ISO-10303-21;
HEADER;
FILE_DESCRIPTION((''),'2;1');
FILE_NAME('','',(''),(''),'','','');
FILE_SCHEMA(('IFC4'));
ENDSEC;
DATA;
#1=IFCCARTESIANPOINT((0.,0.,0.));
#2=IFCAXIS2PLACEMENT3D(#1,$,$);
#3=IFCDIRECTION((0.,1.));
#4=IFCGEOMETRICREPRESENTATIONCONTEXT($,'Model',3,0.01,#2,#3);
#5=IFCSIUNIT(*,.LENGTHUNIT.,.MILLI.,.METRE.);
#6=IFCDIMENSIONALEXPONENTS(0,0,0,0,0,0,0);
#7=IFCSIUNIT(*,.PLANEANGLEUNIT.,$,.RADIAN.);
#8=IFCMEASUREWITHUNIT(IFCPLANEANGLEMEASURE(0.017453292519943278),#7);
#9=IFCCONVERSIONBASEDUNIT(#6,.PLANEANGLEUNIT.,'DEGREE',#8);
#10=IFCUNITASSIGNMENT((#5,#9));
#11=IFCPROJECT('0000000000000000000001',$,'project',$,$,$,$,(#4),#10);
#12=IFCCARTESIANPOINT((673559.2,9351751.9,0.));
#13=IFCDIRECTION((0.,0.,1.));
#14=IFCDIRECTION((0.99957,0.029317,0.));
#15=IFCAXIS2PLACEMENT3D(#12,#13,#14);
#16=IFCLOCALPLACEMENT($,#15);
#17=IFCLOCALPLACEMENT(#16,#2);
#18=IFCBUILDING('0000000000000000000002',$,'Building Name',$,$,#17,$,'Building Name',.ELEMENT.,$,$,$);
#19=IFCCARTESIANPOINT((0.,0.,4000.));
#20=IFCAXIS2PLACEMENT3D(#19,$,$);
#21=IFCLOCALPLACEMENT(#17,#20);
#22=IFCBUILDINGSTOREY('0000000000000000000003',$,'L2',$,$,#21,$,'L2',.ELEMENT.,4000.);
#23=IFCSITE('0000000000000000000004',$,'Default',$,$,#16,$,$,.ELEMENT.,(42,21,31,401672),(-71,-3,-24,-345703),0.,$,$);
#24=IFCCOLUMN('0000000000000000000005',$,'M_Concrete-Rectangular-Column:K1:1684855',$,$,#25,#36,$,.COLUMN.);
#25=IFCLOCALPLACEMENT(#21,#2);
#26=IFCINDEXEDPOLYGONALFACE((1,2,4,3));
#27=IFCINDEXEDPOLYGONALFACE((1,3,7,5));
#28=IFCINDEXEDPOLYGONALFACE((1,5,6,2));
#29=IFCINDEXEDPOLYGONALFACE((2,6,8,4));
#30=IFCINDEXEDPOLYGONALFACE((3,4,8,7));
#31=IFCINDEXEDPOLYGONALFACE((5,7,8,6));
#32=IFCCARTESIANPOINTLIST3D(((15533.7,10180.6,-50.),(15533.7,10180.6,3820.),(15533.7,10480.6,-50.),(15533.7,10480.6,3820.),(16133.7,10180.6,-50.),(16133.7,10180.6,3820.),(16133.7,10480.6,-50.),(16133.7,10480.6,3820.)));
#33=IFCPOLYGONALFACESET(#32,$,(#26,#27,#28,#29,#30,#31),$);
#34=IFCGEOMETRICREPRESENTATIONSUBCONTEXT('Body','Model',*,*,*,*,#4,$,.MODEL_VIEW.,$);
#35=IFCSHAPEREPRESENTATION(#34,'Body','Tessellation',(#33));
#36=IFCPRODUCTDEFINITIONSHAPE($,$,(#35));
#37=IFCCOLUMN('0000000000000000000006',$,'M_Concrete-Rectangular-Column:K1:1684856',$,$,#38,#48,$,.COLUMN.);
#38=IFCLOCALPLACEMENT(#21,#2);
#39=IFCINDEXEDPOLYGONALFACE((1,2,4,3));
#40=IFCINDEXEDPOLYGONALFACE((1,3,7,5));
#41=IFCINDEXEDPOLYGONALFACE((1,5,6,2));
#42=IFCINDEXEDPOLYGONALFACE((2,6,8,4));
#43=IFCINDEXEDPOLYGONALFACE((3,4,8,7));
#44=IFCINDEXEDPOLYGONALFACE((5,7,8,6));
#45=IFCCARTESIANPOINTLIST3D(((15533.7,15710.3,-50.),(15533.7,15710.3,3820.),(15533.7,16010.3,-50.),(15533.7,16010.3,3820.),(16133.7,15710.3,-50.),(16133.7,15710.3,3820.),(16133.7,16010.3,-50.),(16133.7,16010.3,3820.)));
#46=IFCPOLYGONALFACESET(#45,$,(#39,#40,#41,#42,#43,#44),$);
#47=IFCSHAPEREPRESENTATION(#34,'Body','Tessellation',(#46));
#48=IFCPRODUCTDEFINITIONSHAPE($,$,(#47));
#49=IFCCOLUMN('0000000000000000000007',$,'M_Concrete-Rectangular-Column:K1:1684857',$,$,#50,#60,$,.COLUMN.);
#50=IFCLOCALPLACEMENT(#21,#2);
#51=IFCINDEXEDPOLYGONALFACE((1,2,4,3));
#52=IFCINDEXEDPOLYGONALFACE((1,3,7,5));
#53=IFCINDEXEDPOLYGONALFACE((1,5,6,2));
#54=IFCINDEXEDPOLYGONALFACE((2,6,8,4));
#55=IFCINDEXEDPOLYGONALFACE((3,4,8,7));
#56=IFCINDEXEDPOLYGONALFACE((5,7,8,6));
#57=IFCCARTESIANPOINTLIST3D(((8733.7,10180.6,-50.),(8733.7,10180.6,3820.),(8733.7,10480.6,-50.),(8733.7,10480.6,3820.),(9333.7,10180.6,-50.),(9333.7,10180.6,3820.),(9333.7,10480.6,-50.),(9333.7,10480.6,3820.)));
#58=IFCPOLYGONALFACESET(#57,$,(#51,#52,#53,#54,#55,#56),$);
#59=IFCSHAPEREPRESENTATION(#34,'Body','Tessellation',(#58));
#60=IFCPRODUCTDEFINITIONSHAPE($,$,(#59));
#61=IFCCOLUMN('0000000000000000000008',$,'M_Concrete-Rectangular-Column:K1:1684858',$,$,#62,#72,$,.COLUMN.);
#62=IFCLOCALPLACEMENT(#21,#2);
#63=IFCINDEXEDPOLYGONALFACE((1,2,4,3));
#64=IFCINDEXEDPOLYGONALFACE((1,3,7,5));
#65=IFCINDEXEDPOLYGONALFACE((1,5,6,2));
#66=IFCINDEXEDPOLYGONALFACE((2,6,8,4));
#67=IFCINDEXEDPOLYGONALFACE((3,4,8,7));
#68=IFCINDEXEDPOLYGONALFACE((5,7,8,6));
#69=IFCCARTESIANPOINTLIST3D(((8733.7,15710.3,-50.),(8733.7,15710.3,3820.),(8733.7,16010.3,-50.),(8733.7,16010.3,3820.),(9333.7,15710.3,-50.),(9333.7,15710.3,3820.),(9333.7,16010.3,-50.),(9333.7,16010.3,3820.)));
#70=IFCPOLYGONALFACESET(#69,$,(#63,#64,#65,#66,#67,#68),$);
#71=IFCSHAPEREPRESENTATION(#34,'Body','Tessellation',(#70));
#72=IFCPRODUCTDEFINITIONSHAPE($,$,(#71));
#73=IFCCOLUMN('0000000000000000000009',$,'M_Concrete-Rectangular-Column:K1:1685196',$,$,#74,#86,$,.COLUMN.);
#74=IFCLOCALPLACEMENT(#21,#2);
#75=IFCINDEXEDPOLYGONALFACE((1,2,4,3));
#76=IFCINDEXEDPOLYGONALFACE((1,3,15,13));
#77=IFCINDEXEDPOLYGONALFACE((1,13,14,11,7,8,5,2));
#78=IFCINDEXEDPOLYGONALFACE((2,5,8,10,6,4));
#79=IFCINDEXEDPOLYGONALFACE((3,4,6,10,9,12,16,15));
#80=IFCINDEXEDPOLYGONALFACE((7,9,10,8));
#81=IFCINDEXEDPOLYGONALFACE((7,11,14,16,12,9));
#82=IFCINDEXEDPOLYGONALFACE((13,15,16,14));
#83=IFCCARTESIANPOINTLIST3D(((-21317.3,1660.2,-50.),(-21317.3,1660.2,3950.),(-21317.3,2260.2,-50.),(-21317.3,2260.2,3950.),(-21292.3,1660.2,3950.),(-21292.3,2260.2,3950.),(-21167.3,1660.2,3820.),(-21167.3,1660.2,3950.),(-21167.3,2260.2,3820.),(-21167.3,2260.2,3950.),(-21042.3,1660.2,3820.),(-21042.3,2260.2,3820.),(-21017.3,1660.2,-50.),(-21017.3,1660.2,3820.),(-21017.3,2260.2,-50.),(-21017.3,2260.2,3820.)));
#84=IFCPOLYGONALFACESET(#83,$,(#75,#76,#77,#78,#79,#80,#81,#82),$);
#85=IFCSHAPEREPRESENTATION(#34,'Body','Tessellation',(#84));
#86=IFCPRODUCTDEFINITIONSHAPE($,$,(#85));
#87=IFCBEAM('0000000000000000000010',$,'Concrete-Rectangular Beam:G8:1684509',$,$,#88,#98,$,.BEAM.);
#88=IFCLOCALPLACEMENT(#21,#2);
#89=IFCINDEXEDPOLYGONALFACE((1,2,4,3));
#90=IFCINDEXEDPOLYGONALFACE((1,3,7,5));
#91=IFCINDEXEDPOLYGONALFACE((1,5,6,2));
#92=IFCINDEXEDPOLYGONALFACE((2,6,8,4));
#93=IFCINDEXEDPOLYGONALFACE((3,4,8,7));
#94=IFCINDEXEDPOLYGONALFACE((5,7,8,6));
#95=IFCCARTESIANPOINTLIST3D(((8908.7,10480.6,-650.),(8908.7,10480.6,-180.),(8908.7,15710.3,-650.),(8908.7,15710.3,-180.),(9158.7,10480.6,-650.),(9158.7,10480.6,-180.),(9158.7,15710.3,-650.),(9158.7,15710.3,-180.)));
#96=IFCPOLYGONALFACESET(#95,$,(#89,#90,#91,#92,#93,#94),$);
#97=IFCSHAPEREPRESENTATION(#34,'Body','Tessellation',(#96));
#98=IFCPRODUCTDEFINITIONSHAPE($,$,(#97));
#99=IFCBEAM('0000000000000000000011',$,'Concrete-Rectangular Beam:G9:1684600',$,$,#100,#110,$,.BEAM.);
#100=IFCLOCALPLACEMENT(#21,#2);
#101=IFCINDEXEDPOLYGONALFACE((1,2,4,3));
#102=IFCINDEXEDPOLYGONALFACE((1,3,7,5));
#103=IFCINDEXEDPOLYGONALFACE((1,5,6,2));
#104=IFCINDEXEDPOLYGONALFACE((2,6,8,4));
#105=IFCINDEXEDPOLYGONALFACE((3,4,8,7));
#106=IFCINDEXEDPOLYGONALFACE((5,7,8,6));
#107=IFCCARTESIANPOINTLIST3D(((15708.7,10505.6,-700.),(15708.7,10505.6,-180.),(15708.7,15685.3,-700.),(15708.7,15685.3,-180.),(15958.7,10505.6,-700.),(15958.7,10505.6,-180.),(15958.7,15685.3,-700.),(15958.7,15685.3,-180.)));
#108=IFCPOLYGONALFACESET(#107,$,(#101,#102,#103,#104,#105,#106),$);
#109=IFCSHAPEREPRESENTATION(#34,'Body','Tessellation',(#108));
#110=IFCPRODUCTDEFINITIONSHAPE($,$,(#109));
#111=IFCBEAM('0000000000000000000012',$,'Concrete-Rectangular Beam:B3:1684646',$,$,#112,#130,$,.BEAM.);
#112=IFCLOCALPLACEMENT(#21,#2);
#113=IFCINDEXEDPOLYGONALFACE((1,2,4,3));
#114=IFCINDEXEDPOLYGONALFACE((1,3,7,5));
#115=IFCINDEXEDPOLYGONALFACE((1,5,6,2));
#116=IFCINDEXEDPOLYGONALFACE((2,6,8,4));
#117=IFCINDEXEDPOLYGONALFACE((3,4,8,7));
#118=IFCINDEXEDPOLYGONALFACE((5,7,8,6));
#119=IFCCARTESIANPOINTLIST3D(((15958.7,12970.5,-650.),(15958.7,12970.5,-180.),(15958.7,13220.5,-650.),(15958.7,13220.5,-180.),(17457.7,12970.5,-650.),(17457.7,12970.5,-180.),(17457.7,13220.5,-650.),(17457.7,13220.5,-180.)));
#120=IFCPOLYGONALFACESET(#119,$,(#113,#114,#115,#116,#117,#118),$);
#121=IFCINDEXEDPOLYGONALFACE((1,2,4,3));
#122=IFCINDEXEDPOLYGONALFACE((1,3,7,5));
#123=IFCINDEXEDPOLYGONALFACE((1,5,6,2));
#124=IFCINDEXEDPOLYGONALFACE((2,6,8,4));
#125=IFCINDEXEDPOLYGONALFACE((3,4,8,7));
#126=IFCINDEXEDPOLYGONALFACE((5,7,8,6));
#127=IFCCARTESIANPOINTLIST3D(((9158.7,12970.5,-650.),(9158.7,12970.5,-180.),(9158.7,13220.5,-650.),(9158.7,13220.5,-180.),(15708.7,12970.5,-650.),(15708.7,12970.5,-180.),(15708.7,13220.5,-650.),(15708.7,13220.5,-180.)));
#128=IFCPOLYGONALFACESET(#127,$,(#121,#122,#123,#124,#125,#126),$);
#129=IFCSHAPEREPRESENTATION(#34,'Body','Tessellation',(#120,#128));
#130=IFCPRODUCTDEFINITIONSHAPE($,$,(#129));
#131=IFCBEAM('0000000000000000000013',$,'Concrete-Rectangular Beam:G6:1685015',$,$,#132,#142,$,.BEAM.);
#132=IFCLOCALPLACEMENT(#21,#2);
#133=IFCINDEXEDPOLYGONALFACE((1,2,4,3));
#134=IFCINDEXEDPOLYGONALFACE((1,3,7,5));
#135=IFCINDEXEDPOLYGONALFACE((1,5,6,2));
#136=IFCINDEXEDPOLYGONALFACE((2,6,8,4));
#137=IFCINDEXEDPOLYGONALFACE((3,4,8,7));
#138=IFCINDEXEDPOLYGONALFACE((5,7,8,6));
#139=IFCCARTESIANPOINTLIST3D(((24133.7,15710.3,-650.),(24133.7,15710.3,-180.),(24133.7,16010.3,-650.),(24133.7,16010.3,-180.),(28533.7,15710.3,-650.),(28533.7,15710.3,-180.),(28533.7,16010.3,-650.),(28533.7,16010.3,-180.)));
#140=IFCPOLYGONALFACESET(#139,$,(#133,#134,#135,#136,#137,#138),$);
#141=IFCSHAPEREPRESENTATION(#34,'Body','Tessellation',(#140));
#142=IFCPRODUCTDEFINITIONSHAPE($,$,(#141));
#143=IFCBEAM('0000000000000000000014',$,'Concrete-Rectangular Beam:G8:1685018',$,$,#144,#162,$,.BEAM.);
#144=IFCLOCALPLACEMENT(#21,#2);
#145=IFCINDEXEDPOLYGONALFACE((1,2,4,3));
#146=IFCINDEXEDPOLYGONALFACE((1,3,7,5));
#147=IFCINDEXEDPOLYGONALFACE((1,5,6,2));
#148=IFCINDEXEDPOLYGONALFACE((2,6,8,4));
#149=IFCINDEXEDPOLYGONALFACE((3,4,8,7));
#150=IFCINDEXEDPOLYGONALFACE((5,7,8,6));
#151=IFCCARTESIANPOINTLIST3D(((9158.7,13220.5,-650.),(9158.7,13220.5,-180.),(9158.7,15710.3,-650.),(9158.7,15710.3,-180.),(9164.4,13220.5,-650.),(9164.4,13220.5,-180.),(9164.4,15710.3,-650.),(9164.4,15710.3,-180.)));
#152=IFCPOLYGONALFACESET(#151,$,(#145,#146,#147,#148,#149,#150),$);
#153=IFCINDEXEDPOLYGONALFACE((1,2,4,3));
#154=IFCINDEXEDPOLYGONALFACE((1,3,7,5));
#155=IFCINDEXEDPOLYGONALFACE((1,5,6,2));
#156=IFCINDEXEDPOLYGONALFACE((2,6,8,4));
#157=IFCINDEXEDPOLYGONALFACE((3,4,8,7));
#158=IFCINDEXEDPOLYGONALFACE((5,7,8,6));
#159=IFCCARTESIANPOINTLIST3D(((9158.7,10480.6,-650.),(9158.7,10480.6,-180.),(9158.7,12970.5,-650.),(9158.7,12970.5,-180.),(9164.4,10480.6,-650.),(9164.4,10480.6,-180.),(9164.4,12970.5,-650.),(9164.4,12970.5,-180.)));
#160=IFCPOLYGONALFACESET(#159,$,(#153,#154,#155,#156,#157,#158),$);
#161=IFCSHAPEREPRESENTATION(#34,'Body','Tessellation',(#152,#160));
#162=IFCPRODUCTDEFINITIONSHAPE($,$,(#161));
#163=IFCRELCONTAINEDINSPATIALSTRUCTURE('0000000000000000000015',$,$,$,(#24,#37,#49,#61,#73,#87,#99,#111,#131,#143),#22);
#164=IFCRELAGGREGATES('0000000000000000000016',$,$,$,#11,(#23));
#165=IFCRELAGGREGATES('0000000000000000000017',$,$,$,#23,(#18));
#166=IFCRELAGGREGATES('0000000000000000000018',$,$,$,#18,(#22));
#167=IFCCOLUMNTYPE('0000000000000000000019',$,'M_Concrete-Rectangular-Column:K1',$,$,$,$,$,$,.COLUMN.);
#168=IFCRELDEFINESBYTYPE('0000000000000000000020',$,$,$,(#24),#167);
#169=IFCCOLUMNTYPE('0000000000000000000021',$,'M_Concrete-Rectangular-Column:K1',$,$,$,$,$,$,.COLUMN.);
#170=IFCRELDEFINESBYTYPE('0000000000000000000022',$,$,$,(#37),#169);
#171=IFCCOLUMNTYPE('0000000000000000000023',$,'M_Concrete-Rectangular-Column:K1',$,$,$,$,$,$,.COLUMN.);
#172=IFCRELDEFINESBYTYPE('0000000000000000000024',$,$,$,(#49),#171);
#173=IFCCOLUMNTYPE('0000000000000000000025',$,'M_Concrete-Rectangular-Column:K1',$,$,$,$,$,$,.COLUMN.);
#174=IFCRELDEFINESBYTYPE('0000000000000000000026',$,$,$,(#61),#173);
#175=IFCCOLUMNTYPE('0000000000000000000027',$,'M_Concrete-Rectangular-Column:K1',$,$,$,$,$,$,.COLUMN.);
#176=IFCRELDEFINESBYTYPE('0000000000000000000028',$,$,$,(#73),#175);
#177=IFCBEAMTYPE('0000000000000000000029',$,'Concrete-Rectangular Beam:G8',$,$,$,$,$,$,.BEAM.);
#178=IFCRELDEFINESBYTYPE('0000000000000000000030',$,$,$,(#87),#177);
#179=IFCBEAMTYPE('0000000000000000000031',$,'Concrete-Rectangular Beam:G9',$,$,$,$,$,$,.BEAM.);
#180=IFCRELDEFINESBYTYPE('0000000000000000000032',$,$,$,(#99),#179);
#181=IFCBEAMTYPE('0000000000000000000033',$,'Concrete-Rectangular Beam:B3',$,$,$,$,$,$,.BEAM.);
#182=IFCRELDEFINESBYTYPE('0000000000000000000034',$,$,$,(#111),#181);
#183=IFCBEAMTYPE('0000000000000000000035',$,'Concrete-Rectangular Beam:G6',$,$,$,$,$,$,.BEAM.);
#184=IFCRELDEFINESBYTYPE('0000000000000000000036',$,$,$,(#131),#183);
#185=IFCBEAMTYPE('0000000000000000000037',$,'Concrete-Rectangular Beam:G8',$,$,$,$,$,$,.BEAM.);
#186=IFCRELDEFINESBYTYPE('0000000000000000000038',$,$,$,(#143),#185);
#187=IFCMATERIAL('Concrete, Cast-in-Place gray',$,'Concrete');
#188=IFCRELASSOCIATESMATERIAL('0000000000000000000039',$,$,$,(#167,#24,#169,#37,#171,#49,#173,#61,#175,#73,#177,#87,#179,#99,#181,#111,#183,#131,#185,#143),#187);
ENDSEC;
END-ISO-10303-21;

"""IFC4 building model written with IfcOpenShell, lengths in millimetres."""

from ifc_helpers import new_model, entity, si_unit, converted_unit, direction, frame, origin, place, context, subcontext, project, spatial, indexed_curve, outline, extrude, source, transform, mapped, material, type_object, type_shapes, element, save


model = new_model("IFC4")

# Units and contexts
model_context = context("Model", 3, precision=0.01, world=origin(), true_north=direction((0.0, 1.0)))
body_context = subcontext(model_context, "Body", "Model", "MODEL_VIEW")
ifc_project = project(units=[si_unit("LENGTHUNIT", "METRE", prefix="MILLI"), converted_unit("PLANEANGLEUNIT", "DEGREE", entity("IfcPlaneAngleMeasure", 0.017453292519943278), si_unit("PLANEANGLEUNIT", "RADIAN"), dimensions=[0, 0, 0, 0, 0, 0, 0])], contexts=[model_context])

# Site, building, storey
site_placement = place(None, frame((673559.2, 9351751.9, 0.0), z_axis=(0.0, 0.0, 1.0), x_axis=(0.99957, 0.029317, 0.0)))
site = spatial("IfcSite", under=ifc_project, at=site_placement, Name="Default", CompositionType="ELEMENT", RefLatitude=(42, 21, 31, 401672), RefLongitude=(-71, -3, -24, -345703), RefElevation=0.0)
building_placement = place(site_placement, origin())
building = spatial("IfcBuilding", under=site, at=building_placement, Name="Building Name", LongName="Building Name", CompositionType="ELEMENT")
storey_placement = place(building_placement, frame((0.0, 0.0, 4000.0)))
storey = spatial("IfcBuildingStorey", under=building, at=storey_placement, Name="L2", LongName="L2", CompositionType="ELEMENT", Elevation=4000.0)

# Columns
ifc_material = material(Name="Concrete, Cast-in-Place gray", Category="Concrete")
column_type_1 = type_object("IfcColumnType", Name="M_Concrete-Rectangular-Column:K1", PredefinedType="COLUMN", material=ifc_material)
shared_shape_1 = source(origin(), body_context, "Body", "SweptSolid", [
    extrude(outline(indexed_curve([(-150.0, -300.0), (150.0, -300.0), (150.0, 300.0), (-150.0, 300.0), (-150.0, -300.0)], self_intersect=False)), frame((15833.7, 10330.6, 3950.0), z_axis=(0.0, 0.0, 1.0), x_axis=(0.0, -1.0, 0.0)), (0.0, 0.0, 1.0), 3870.0),
])
type_shapes(column_type_1, [shared_shape_1])
column_1_placement = place(storey_placement, frame((0.0, 0.0, -4000.0)))
element("IfcColumn", 1, at=column_1_placement, inside=storey, type_object=column_type_1, material=ifc_material, Name="M_Concrete-Rectangular-Column:K1:1684855", PredefinedType="COLUMN", context=body_context, shape_type="MappedRepresentation", body=[
    mapped(shared_shape_1, transform((0.0, 0.0, 0.0), scale=1.0)),
])
column_type_2 = type_object("IfcColumnType", Name="M_Concrete-Rectangular-Column:K1", PredefinedType="COLUMN", material=ifc_material)
shared_shape_2 = source(origin(), body_context, "Body", "SweptSolid", [
    extrude(outline(indexed_curve([(-150.0, -300.0), (150.0, -300.0), (150.0, 300.0), (-150.0, 300.0), (-150.0, -300.0)], self_intersect=False)), frame((15833.7, 15860.3, 3950.0), z_axis=(0.0, 0.0, 1.0), x_axis=(0.0, -1.0, 0.0)), (0.0, 0.0, 1.0), 3870.0),
])
type_shapes(column_type_2, [shared_shape_2])
column_2_placement = place(storey_placement, frame((0.0, 0.0, -4000.0)))
element("IfcColumn", 2, at=column_2_placement, inside=storey, type_object=column_type_2, material=ifc_material, Name="M_Concrete-Rectangular-Column:K1:1684856", PredefinedType="COLUMN", context=body_context, shape_type="MappedRepresentation", body=[
    mapped(shared_shape_2, transform((0.0, 0.0, 0.0), scale=1.0)),
])
column_type_3 = type_object("IfcColumnType", Name="M_Concrete-Rectangular-Column:K1", PredefinedType="COLUMN", material=ifc_material)
shared_shape_3 = source(origin(), body_context, "Body", "SweptSolid", [
    extrude(outline(indexed_curve([(-150.0, -300.0), (150.0, -300.0), (150.0, 300.0), (-150.0, 300.0), (-150.0, -300.0)], self_intersect=False)), frame((9033.7, 10330.6, 3950.0), z_axis=(0.0, 0.0, 1.0), x_axis=(0.0, -1.0, 0.0)), (0.0, 0.0, 1.0), 3870.0),
])
type_shapes(column_type_3, [shared_shape_3])
column_3_placement = place(storey_placement, frame((0.0, 0.0, -4000.0)))
element("IfcColumn", 3, at=column_3_placement, inside=storey, type_object=column_type_3, material=ifc_material, Name="M_Concrete-Rectangular-Column:K1:1684857", PredefinedType="COLUMN", context=body_context, shape_type="MappedRepresentation", body=[
    mapped(shared_shape_3, transform((0.0, 0.0, 0.0), scale=1.0)),
])
column_type_4 = type_object("IfcColumnType", Name="M_Concrete-Rectangular-Column:K1", PredefinedType="COLUMN", material=ifc_material)
shared_shape_4 = source(origin(), body_context, "Body", "SweptSolid", [
    extrude(outline(indexed_curve([(-150.0, -300.0), (150.0, -300.0), (150.0, 300.0), (-150.0, 300.0), (-150.0, -300.0)], self_intersect=False)), frame((9033.7, 15860.3, 3950.0), z_axis=(0.0, 0.0, 1.0), x_axis=(0.0, -1.0, 0.0)), (0.0, 0.0, 1.0), 3870.0),
])
type_shapes(column_type_4, [shared_shape_4])
column_4_placement = place(storey_placement, frame((0.0, 0.0, -4000.0)))
element("IfcColumn", 4, at=column_4_placement, inside=storey, type_object=column_type_4, material=ifc_material, Name="M_Concrete-Rectangular-Column:K1:1684858", PredefinedType="COLUMN", context=body_context, shape_type="MappedRepresentation", body=[
    mapped(shared_shape_4, transform((0.0, 0.0, 0.0), scale=1.0)),
])
column_type_5 = type_object("IfcColumnType", Name="M_Concrete-Rectangular-Column:K1", PredefinedType="COLUMN", material=ifc_material)
shared_shape_5 = source(origin(), body_context, "Body", "SweptSolid", [
    extrude(outline(indexed_curve([(-2951.3, -150.0), (1048.7, -150.0), (1048.7, -125.0), (1048.7, 0.0), (918.8, 0.0), (918.8, 125.0), (918.8, 150.0), (-2951.3, 150.0), (-2951.3, -150.0)], self_intersect=False)), frame((-21167.3, 1660.2, 6901.3), z_axis=(0.0, 1.0, 0.0), x_axis=(0.0, 0.0, 1.0)), (0.0, 0.0, 1.0), 600.0),
])
type_shapes(column_type_5, [shared_shape_5])
column_5_placement = place(storey_placement, frame((0.0, 0.0, -4000.0)))
element("IfcColumn", 5, at=column_5_placement, inside=storey, type_object=column_type_5, material=ifc_material, Name="M_Concrete-Rectangular-Column:K1:1685196", PredefinedType="COLUMN", context=body_context, shape_type="MappedRepresentation", body=[
    mapped(shared_shape_5, transform((0.0, 0.0, 0.0), scale=1.0)),
])

# Beams
beam_type_1 = type_object("IfcBeamType", Name="Concrete-Rectangular Beam:G8", PredefinedType="BEAM", material=ifc_material)
shared_shape_6 = source(origin(), body_context, "Body", "SweptSolid", [
    extrude(outline(indexed_curve([(-125.0, -235.0), (125.0, -235.0), (125.0, 235.0), (-125.0, 235.0), (-125.0, -235.0)], self_intersect=False)), frame((9033.7, 15710.3, 3585.0), z_axis=(0.0, -1.0, 0.0), x_axis=(-1.0, 0.0, 0.0)), (0.0, 0.0, 1.0), 5229.7),
])
type_shapes(beam_type_1, [shared_shape_6])
beam_1_placement = place(storey_placement, frame((0.0, 0.0, -4000.0)))
element("IfcBeam", 6, at=beam_1_placement, inside=storey, type_object=beam_type_1, material=ifc_material, Name="Concrete-Rectangular Beam:G8:1684509", PredefinedType="BEAM", context=body_context, shape_type="MappedRepresentation", body=[
    mapped(shared_shape_6, transform((0.0, 0.0, 0.0), scale=1.0)),
])
beam_type_2 = type_object("IfcBeamType", Name="Concrete-Rectangular Beam:G9", PredefinedType="BEAM", material=ifc_material)
shared_shape_7 = source(origin(), body_context, "Body", "SweptSolid", [
    extrude(outline(indexed_curve([(-125.0, -260.0), (125.0, -260.0), (125.0, 260.0), (-125.0, 260.0), (-125.0, -260.0)], self_intersect=False)), frame((15833.7, 15685.3, 3560.0), z_axis=(0.0, -1.0, 0.0), x_axis=(-1.0, 0.0, 0.0)), (0.0, 0.0, 1.0), 5179.7),
])
type_shapes(beam_type_2, [shared_shape_7])
beam_2_placement = place(storey_placement, frame((0.0, 0.0, -4000.0)))
element("IfcBeam", 7, at=beam_2_placement, inside=storey, type_object=beam_type_2, material=ifc_material, Name="Concrete-Rectangular Beam:G9:1684600", PredefinedType="BEAM", context=body_context, shape_type="MappedRepresentation", body=[
    mapped(shared_shape_7, transform((0.0, 0.0, 0.0), scale=1.0)),
])
beam_type_3 = type_object("IfcBeamType", Name="Concrete-Rectangular Beam:B3", PredefinedType="BEAM", material=ifc_material)
shared_shape_8 = source(origin(), body_context, "Body", "SweptSolid", [
    extrude(outline(indexed_curve([(-235.0, -125.0), (235.0, -125.0), (235.0, 125.0), (-235.0, 125.0), (-235.0, -125.0)], self_intersect=False)), frame((15958.7, 13095.5, 3585.0), z_axis=(1.0, 0.0, 0.0), x_axis=(0.0, 0.0, -1.0)), (0.0, 0.0, 1.0), 1499.0),
    extrude(outline(indexed_curve([(-235.0, -125.0), (235.0, -125.0), (235.0, 125.0), (-235.0, 125.0), (-235.0, -125.0)], self_intersect=False)), frame((9158.7, 13095.5, 3585.0), z_axis=(1.0, 0.0, 0.0), x_axis=(0.0, 0.0, -1.0)), (0.0, 0.0, 1.0), 6550.0),
])
type_shapes(beam_type_3, [shared_shape_8])
beam_3_placement = place(storey_placement, frame((0.0, 0.0, -4000.0)))
element("IfcBeam", 8, at=beam_3_placement, inside=storey, type_object=beam_type_3, material=ifc_material, Name="Concrete-Rectangular Beam:B3:1684646", PredefinedType="BEAM", context=body_context, shape_type="MappedRepresentation", body=[
    mapped(shared_shape_8, transform((0.0, 0.0, 0.0), scale=1.0)),
])
beam_type_4 = type_object("IfcBeamType", Name="Concrete-Rectangular Beam:G6", PredefinedType="BEAM", material=ifc_material)
shared_shape_9 = source(origin(), body_context, "Body", "SweptSolid", [
    extrude(outline(indexed_curve([(-235.0, -150.0), (235.0, -150.0), (235.0, 150.0), (-235.0, 150.0), (-235.0, -150.0)], self_intersect=False)), frame((24133.7, 15860.3, 3585.0), z_axis=(1.0, 0.0, 0.0), x_axis=(0.0, 0.0, -1.0)), (0.0, 0.0, 1.0), 4400.0),
])
type_shapes(beam_type_4, [shared_shape_9])
beam_4_placement = place(storey_placement, frame((0.0, 0.0, -4000.0)))
element("IfcBeam", 9, at=beam_4_placement, inside=storey, type_object=beam_type_4, material=ifc_material, Name="Concrete-Rectangular Beam:G6:1685015", PredefinedType="BEAM", context=body_context, shape_type="MappedRepresentation", body=[
    mapped(shared_shape_9, transform((0.0, 0.0, 0.0), scale=1.0)),
])
beam_type_5 = type_object("IfcBeamType", Name="Concrete-Rectangular Beam:G8", PredefinedType="BEAM", material=ifc_material)
shared_shape_10 = source(origin(), body_context, "Body", "SweptSolid", [
    extrude(outline(indexed_curve([(-2.8, -235.0), (2.8, -235.0), (2.8, 235.0), (-2.8, 235.0), (-2.8, -235.0)], self_intersect=False)), frame((9161.5, 13220.5, 3585.0), z_axis=(0.0, 1.0, 0.0), x_axis=(-1.0, 0.0, 0.0)), (0.0, 0.0, 1.0), 2489.8),
    extrude(outline(indexed_curve([(-2.8, -235.0), (2.8, -235.0), (2.8, 235.0), (-2.8, 235.0), (-2.8, -235.0)], self_intersect=False)), frame((9161.5, 10480.6, 3585.0), z_axis=(0.0, 1.0, 0.0), x_axis=(-1.0, 0.0, 0.0)), (0.0, 0.0, 1.0), 2489.8),
])
type_shapes(beam_type_5, [shared_shape_10])
beam_5_placement = place(storey_placement, frame((0.0, 0.0, -4000.0)))
element("IfcBeam", 10, at=beam_5_placement, inside=storey, type_object=beam_type_5, material=ifc_material, Name="Concrete-Rectangular Beam:G8:1685018", PredefinedType="BEAM", context=body_context, shape_type="MappedRepresentation", body=[
    mapped(shared_shape_10, transform((0.0, 0.0, 0.0), scale=1.0)),
])

save(model, "model.ifc")
